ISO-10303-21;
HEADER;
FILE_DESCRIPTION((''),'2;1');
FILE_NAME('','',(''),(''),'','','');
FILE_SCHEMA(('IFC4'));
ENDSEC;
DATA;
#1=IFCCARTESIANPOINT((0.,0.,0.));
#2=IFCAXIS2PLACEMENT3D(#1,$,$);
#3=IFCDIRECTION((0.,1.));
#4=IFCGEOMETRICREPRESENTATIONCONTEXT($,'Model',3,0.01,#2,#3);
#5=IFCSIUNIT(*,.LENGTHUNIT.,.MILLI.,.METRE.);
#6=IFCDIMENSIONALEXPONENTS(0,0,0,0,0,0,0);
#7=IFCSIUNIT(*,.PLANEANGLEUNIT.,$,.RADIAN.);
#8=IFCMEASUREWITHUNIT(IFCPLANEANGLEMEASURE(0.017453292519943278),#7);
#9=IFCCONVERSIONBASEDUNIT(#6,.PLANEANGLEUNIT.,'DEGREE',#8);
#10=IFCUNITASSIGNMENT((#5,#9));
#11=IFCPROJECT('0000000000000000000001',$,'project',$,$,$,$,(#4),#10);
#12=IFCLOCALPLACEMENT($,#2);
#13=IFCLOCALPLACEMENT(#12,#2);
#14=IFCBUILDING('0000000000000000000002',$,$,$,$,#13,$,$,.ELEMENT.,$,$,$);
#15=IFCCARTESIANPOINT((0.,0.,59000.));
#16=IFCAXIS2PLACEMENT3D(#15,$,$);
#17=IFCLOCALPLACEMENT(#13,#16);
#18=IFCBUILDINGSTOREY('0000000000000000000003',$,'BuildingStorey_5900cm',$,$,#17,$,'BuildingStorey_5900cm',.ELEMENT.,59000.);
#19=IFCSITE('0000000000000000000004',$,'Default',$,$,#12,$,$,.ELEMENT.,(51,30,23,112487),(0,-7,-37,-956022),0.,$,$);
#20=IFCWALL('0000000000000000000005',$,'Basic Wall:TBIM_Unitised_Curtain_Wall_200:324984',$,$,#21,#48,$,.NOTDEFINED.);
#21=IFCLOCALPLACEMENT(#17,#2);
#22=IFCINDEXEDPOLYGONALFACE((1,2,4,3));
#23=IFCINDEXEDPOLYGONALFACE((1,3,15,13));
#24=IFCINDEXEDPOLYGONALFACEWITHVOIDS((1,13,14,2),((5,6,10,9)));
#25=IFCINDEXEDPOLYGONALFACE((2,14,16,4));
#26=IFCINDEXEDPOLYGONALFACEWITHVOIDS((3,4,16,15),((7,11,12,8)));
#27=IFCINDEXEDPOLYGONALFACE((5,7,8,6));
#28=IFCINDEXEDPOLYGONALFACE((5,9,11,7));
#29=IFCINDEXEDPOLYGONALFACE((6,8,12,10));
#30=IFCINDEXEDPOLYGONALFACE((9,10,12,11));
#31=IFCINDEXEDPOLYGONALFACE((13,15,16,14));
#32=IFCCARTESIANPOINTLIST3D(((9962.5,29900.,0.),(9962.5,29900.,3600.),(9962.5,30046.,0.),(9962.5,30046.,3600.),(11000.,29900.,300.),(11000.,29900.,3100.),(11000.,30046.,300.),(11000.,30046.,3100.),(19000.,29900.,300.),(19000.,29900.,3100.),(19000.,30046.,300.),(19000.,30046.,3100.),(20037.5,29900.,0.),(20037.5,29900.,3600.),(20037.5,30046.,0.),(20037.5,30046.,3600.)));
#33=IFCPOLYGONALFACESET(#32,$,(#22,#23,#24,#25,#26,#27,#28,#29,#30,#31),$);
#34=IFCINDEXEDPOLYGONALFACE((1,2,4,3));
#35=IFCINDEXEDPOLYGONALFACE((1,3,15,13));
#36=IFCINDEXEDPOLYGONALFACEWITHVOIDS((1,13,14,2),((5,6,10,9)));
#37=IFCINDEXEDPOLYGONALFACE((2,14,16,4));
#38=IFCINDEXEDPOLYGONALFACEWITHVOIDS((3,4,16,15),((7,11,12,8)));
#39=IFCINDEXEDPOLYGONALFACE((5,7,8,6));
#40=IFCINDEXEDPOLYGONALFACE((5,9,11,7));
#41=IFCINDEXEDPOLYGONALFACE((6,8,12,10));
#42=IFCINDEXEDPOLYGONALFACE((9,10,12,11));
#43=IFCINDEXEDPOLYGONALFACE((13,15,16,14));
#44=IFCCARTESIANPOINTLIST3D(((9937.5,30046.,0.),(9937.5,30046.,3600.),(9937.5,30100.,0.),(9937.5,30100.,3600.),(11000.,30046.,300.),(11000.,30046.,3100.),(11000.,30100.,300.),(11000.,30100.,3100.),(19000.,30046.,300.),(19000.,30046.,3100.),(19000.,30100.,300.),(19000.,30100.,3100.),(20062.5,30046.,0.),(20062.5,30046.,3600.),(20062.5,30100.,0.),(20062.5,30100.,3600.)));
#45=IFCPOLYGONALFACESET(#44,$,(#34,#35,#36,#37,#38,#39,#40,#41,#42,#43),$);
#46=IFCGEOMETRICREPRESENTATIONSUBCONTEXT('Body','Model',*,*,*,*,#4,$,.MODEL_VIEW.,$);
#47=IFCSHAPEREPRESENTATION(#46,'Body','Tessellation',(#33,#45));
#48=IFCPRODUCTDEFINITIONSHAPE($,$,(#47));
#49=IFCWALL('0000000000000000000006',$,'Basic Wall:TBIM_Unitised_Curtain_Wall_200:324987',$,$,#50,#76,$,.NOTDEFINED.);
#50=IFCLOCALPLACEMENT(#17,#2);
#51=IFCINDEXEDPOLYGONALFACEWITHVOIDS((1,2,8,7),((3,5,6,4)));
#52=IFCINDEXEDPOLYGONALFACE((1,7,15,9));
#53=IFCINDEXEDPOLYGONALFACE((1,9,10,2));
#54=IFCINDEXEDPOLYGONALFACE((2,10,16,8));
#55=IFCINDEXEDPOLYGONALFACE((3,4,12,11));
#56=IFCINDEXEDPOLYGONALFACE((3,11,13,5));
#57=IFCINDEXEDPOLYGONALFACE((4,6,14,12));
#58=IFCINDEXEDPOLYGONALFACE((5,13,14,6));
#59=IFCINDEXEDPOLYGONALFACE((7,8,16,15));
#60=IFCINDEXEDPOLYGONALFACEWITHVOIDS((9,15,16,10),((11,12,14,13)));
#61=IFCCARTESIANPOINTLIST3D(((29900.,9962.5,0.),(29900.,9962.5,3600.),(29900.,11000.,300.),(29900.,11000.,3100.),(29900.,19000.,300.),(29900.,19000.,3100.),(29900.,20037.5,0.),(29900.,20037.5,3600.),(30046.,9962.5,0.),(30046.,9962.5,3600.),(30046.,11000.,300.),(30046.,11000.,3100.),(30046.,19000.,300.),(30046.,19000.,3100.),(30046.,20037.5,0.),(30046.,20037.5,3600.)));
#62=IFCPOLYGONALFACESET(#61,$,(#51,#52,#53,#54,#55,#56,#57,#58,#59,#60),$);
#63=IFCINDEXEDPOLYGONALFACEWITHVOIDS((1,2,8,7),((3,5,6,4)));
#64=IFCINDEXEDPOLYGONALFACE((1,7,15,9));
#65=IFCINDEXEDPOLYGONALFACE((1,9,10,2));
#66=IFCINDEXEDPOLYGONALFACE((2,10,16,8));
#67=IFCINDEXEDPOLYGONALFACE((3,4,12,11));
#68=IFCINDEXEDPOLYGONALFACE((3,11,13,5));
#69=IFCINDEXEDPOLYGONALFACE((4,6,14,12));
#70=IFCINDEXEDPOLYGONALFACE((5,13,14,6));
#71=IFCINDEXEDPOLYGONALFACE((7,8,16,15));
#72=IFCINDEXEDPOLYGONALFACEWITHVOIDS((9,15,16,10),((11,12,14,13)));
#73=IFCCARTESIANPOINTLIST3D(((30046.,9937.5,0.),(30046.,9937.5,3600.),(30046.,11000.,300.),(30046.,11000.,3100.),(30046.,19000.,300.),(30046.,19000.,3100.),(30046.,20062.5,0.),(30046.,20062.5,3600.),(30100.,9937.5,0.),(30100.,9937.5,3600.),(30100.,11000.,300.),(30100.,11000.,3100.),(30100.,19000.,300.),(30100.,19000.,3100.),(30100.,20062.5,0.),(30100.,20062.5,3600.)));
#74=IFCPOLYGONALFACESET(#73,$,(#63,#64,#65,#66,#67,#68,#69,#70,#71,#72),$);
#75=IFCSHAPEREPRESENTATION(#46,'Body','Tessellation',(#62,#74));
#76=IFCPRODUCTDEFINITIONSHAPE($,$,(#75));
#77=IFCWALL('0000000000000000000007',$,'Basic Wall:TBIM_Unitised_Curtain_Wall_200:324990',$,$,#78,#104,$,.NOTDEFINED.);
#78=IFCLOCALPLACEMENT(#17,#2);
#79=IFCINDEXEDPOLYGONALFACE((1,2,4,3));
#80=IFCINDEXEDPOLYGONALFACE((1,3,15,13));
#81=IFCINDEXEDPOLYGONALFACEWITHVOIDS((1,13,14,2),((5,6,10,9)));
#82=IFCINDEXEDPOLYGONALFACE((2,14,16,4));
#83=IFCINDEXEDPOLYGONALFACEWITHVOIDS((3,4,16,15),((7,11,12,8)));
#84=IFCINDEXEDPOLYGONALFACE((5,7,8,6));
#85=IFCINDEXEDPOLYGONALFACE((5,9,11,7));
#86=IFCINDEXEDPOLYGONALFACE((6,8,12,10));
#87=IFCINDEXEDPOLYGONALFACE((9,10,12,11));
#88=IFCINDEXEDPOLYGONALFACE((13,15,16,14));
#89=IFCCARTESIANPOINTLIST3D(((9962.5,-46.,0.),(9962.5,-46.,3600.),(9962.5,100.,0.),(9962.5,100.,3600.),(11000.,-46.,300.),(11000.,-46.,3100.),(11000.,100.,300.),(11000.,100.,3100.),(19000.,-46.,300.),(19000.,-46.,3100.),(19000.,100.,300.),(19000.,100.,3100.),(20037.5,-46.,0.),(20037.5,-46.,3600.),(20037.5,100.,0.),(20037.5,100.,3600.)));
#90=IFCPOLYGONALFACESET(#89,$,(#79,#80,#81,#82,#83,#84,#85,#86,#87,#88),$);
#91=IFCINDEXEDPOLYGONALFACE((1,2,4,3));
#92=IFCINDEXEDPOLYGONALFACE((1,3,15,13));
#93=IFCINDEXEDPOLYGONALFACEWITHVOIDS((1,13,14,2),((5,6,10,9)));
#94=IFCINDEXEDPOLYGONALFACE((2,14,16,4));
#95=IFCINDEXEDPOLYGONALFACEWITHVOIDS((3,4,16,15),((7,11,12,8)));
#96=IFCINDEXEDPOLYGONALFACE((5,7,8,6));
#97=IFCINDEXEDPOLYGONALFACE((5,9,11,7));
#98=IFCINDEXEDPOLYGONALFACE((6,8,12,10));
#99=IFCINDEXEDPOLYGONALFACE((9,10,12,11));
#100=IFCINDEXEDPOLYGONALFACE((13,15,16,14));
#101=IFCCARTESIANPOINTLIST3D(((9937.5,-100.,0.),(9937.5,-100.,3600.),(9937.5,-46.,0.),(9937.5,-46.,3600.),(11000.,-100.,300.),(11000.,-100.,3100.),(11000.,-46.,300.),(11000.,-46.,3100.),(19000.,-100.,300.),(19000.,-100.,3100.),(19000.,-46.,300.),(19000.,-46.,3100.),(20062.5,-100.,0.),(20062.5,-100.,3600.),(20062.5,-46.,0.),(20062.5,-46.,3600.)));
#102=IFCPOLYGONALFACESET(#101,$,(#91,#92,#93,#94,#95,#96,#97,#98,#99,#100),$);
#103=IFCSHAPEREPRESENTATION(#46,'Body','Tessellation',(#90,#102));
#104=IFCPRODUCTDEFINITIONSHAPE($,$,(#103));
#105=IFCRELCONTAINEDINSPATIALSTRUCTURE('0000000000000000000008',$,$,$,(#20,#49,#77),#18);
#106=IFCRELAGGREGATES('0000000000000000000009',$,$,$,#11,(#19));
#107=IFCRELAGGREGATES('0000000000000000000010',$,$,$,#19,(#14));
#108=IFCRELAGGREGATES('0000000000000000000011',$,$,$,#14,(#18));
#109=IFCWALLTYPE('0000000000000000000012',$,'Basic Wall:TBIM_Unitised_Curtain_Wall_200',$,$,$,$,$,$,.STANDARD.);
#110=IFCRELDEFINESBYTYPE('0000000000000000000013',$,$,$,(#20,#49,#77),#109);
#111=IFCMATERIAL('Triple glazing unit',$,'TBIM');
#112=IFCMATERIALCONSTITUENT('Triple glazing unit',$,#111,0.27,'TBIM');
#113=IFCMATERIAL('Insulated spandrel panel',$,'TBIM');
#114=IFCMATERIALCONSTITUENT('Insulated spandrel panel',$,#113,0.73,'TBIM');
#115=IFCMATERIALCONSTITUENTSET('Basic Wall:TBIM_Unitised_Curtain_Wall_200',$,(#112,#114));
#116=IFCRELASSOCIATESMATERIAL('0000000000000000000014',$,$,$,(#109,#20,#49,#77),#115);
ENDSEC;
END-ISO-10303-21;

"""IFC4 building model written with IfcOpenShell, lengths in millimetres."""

from ifc_helpers import new_model, entity, si_unit, converted_unit, direction, frame, origin, place, context, subcontext, project, spatial, indexed_curve, outline, extrude, material, constituent, constituent_set, type_object, element, save


model = new_model("IFC4")

# Units and contexts
model_context = context("Model", 3, precision=0.01, world=origin(), true_north=direction((0.0, 1.0)))
body_context = subcontext(model_context, "Body", "Model", "MODEL_VIEW")
ifc_project = project(units=[si_unit("LENGTHUNIT", "METRE", prefix="MILLI"), converted_unit("PLANEANGLEUNIT", "DEGREE", entity("IfcPlaneAngleMeasure", 0.017453292519943278), si_unit("PLANEANGLEUNIT", "RADIAN"), dimensions=[0, 0, 0, 0, 0, 0, 0])], contexts=[model_context])

# Site, building, storey
site_placement = place(None, origin())
site = spatial("IfcSite", under=ifc_project, at=site_placement, Name="Default", CompositionType="ELEMENT", RefLatitude=(51, 30, 23, 112487), RefLongitude=(0, -7, -37, -956022), RefElevation=0.0)
building_placement = place(site_placement, origin())
building = spatial("IfcBuilding", under=site, at=building_placement, CompositionType="ELEMENT")
storey_placement = place(building_placement, frame((0.0, 0.0, 59000.0)))
storey = spatial("IfcBuildingStorey", under=building, at=storey_placement, Name="BuildingStorey_5900cm", LongName="BuildingStorey_5900cm", CompositionType="ELEMENT", Elevation=59000.0)

# Walls, openings
ifc_material_1 = material(Name="Triple glazing unit", Category="TBIM")
ifc_constituent_1 = constituent(ifc_material_1, Name="Triple glazing unit", Category="TBIM", fraction=0.27)
ifc_material_2 = material(Name="Insulated spandrel panel", Category="TBIM")
ifc_constituent_2 = constituent(ifc_material_2, Name="Insulated spandrel panel", Category="TBIM", fraction=0.73)
ifc_constituent_set_1 = constituent_set(constituents=[ifc_constituent_1, ifc_constituent_2], Name="Basic Wall:TBIM_Unitised_Curtain_Wall_200")
wall_type_1 = type_object("IfcWallType", Name="Basic Wall:TBIM_Unitised_Curtain_Wall_200", PredefinedType="STANDARD", material=ifc_constituent_set_1)
wall_1_placement = place(storey_placement, frame((9937.5, 30000.0, 0.0)))
wall_1 = element("IfcWall", 1, at=wall_1_placement, inside=storey, type_object=wall_type_1, material=ifc_constituent_set_1, Name="Basic Wall:TBIM_Unitised_Curtain_Wall_200:324984", PredefinedType="NOTDEFINED", context=body_context, shape_type="SweptSolid", body=[
    extrude(outline(indexed_curve([(-1800.0, -5037.5), (1800.0, -5037.5), (1800.0, -4937.5), (1800.0, 4937.5), (1800.0, 5037.5), (-1800.0, 5037.5), (-1800.0, 4937.5), (-1800.0, -4937.5), (-1800.0, -5037.5)], self_intersect=False), holes=[indexed_curve([(1300.0, -4000.0), (-1500.0, -4000.0), (-1500.0, 4000.0), (1300.0, 4000.0), (1300.0, -4000.0)], self_intersect=False)]), frame((5062.5, -100.0, 1800.0), z_axis=(0.0, 1.0, 0.0), x_axis=(0.0, 0.0, 1.0)), (0.0, 0.0, 1.0), 146.0),
    extrude(outline(indexed_curve([(-1800.0, -5062.5), (1800.0, -5062.5), (1800.0, 5062.5), (-1800.0, 5062.5), (-1800.0, -5062.5)], self_intersect=False), holes=[indexed_curve([(-1500.0, -4000.0), (-1500.0, 4000.0), (1300.0, 4000.0), (1300.0, -4000.0), (-1500.0, -4000.0)], self_intersect=False)]), frame((5062.5, 46.0, 1800.0), z_axis=(0.0, 1.0, 0.0), x_axis=(0.0, 0.0, 1.0)), (0.0, 0.0, 1.0), 54.0),
])
opening_1_placement = place(wall_1_placement, frame((1062.5, -100.0, 300.0)))
element("IfcOpeningElement", 2, at=opening_1_placement, cuts=wall_1, PredefinedType="OPENING", context=body_context, shape_type="SweptSolid", body=[
    extrude(outline(indexed_curve([(2800.0, 0.0), (2800.0, 8000.0), (0.0, 8000.0), (0.0, 0.0), (2800.0, 0.0)], self_intersect=False)), frame((0.0, 0.0, 0.0), z_axis=(0.0, 1.0, 0.0), x_axis=(0.0, 0.0, 1.0)), (0.0, 0.0, 1.0), 200.0),
])
wall_2_placement = place(storey_placement, frame((30000.0, 9937.5, 0.0), z_axis=(0.0, 0.0, 1.0), x_axis=(0.0, 1.0, 0.0)))
wall_2 = element("IfcWall", 3, at=wall_2_placement, inside=storey, type_object=wall_type_1, material=ifc_constituent_set_1, Name="Basic Wall:TBIM_Unitised_Curtain_Wall_200:324987", PredefinedType="NOTDEFINED", context=body_context, shape_type="SweptSolid", body=[
    extrude(outline(indexed_curve([(-5037.5, -1800.0), (-4937.5, -1800.0), (4937.5, -1800.0), (5037.5, -1800.0), (5037.5, 1800.0), (4937.5, 1800.0), (-4937.5, 1800.0), (-5037.5, 1800.0), (-5037.5, -1800.0)], self_intersect=False), holes=[indexed_curve([(-4000.0, 1300.0), (4000.0, 1300.0), (4000.0, -1500.0), (-4000.0, -1500.0), (-4000.0, 1300.0)], self_intersect=False)]), frame((5062.5, 100.0, 1800.0), z_axis=(0.0, -1.0, 0.0), x_axis=(1.0, 0.0, 0.0)), (0.0, 0.0, 1.0), 146.0),
    extrude(outline(indexed_curve([(-1800.0, -5062.5), (1800.0, -5062.5), (1800.0, 5062.5), (-1800.0, 5062.5), (-1800.0, -5062.5)], self_intersect=False), holes=[indexed_curve([(1300.0, 4000.0), (1300.0, -4000.0), (-1500.0, -4000.0), (-1500.0, 4000.0), (1300.0, 4000.0)], self_intersect=False)]), frame((5062.5, -46.0, 1800.0), z_axis=(0.0, -1.0, 0.0), x_axis=(0.0, 0.0, 1.0)), (0.0, 0.0, 1.0), 54.0),
])
opening_2_placement = place(wall_2_placement, frame((1062.5, -100.0, 300.0)))
element("IfcOpeningElement", 4, at=opening_2_placement, cuts=wall_2, PredefinedType="OPENING", context=body_context, shape_type="SweptSolid", body=[
    extrude(outline(indexed_curve([(2800.0, 0.0), (2800.0, 8000.0), (0.0, 8000.0), (0.0, 0.0), (2800.0, 0.0)], self_intersect=False)), frame((0.0, 0.0, 0.0), z_axis=(0.0, 1.0, 0.0), x_axis=(0.0, 0.0, 1.0)), (0.0, 0.0, 1.0), 200.0),
])
wall_3_placement = place(storey_placement, frame((9937.5, 0.0, 0.0)))
wall_3 = element("IfcWall", 5, at=wall_3_placement, inside=storey, type_object=wall_type_1, material=ifc_constituent_set_1, Name="Basic Wall:TBIM_Unitised_Curtain_Wall_200:324990", PredefinedType="NOTDEFINED", context=body_context, shape_type="SweptSolid", body=[
    extrude(outline(indexed_curve([(-1800.0, -5037.5), (1800.0, -5037.5), (1800.0, 5037.5), (-1800.0, 5037.5), (-1800.0, -5037.5)], self_intersect=False), holes=[indexed_curve([(-1500.0, -4000.0), (-1500.0, 4000.0), (1300.0, 4000.0), (1300.0, -4000.0), (-1500.0, -4000.0)], self_intersect=False)]), frame((5062.5, -46.0, 1800.0), z_axis=(0.0, 1.0, 0.0), x_axis=(0.0, 0.0, 1.0)), (0.0, 0.0, 1.0), 146.0),
    extrude(outline(indexed_curve([(-1800.0, -5062.5), (1800.0, -5062.5), (1800.0, 5062.5), (-1800.0, 5062.5), (-1800.0, -5062.5)], self_intersect=False), holes=[indexed_curve([(1300.0, -4000.0), (-1500.0, -4000.0), (-1500.0, 4000.0), (1300.0, 4000.0), (1300.0, -4000.0)], self_intersect=False)]), frame((5062.5, -100.0, 1800.0), z_axis=(0.0, 1.0, 0.0), x_axis=(0.0, 0.0, 1.0)), (0.0, 0.0, 1.0), 54.0),
])
opening_3_placement = place(wall_3_placement, frame((1062.5, -100.0, 300.0)))
element("IfcOpeningElement", 6, at=opening_3_placement, cuts=wall_3, PredefinedType="OPENING", context=body_context, shape_type="SweptSolid", body=[
    extrude(outline(indexed_curve([(2800.0, 0.0), (2800.0, 8000.0), (0.0, 8000.0), (0.0, 0.0), (2800.0, 0.0)], self_intersect=False)), frame((0.0, 0.0, 0.0), z_axis=(0.0, 1.0, 0.0), x_axis=(0.0, 0.0, 1.0)), (0.0, 0.0, 1.0), 200.0),
])

save(model, "model.ifc")
